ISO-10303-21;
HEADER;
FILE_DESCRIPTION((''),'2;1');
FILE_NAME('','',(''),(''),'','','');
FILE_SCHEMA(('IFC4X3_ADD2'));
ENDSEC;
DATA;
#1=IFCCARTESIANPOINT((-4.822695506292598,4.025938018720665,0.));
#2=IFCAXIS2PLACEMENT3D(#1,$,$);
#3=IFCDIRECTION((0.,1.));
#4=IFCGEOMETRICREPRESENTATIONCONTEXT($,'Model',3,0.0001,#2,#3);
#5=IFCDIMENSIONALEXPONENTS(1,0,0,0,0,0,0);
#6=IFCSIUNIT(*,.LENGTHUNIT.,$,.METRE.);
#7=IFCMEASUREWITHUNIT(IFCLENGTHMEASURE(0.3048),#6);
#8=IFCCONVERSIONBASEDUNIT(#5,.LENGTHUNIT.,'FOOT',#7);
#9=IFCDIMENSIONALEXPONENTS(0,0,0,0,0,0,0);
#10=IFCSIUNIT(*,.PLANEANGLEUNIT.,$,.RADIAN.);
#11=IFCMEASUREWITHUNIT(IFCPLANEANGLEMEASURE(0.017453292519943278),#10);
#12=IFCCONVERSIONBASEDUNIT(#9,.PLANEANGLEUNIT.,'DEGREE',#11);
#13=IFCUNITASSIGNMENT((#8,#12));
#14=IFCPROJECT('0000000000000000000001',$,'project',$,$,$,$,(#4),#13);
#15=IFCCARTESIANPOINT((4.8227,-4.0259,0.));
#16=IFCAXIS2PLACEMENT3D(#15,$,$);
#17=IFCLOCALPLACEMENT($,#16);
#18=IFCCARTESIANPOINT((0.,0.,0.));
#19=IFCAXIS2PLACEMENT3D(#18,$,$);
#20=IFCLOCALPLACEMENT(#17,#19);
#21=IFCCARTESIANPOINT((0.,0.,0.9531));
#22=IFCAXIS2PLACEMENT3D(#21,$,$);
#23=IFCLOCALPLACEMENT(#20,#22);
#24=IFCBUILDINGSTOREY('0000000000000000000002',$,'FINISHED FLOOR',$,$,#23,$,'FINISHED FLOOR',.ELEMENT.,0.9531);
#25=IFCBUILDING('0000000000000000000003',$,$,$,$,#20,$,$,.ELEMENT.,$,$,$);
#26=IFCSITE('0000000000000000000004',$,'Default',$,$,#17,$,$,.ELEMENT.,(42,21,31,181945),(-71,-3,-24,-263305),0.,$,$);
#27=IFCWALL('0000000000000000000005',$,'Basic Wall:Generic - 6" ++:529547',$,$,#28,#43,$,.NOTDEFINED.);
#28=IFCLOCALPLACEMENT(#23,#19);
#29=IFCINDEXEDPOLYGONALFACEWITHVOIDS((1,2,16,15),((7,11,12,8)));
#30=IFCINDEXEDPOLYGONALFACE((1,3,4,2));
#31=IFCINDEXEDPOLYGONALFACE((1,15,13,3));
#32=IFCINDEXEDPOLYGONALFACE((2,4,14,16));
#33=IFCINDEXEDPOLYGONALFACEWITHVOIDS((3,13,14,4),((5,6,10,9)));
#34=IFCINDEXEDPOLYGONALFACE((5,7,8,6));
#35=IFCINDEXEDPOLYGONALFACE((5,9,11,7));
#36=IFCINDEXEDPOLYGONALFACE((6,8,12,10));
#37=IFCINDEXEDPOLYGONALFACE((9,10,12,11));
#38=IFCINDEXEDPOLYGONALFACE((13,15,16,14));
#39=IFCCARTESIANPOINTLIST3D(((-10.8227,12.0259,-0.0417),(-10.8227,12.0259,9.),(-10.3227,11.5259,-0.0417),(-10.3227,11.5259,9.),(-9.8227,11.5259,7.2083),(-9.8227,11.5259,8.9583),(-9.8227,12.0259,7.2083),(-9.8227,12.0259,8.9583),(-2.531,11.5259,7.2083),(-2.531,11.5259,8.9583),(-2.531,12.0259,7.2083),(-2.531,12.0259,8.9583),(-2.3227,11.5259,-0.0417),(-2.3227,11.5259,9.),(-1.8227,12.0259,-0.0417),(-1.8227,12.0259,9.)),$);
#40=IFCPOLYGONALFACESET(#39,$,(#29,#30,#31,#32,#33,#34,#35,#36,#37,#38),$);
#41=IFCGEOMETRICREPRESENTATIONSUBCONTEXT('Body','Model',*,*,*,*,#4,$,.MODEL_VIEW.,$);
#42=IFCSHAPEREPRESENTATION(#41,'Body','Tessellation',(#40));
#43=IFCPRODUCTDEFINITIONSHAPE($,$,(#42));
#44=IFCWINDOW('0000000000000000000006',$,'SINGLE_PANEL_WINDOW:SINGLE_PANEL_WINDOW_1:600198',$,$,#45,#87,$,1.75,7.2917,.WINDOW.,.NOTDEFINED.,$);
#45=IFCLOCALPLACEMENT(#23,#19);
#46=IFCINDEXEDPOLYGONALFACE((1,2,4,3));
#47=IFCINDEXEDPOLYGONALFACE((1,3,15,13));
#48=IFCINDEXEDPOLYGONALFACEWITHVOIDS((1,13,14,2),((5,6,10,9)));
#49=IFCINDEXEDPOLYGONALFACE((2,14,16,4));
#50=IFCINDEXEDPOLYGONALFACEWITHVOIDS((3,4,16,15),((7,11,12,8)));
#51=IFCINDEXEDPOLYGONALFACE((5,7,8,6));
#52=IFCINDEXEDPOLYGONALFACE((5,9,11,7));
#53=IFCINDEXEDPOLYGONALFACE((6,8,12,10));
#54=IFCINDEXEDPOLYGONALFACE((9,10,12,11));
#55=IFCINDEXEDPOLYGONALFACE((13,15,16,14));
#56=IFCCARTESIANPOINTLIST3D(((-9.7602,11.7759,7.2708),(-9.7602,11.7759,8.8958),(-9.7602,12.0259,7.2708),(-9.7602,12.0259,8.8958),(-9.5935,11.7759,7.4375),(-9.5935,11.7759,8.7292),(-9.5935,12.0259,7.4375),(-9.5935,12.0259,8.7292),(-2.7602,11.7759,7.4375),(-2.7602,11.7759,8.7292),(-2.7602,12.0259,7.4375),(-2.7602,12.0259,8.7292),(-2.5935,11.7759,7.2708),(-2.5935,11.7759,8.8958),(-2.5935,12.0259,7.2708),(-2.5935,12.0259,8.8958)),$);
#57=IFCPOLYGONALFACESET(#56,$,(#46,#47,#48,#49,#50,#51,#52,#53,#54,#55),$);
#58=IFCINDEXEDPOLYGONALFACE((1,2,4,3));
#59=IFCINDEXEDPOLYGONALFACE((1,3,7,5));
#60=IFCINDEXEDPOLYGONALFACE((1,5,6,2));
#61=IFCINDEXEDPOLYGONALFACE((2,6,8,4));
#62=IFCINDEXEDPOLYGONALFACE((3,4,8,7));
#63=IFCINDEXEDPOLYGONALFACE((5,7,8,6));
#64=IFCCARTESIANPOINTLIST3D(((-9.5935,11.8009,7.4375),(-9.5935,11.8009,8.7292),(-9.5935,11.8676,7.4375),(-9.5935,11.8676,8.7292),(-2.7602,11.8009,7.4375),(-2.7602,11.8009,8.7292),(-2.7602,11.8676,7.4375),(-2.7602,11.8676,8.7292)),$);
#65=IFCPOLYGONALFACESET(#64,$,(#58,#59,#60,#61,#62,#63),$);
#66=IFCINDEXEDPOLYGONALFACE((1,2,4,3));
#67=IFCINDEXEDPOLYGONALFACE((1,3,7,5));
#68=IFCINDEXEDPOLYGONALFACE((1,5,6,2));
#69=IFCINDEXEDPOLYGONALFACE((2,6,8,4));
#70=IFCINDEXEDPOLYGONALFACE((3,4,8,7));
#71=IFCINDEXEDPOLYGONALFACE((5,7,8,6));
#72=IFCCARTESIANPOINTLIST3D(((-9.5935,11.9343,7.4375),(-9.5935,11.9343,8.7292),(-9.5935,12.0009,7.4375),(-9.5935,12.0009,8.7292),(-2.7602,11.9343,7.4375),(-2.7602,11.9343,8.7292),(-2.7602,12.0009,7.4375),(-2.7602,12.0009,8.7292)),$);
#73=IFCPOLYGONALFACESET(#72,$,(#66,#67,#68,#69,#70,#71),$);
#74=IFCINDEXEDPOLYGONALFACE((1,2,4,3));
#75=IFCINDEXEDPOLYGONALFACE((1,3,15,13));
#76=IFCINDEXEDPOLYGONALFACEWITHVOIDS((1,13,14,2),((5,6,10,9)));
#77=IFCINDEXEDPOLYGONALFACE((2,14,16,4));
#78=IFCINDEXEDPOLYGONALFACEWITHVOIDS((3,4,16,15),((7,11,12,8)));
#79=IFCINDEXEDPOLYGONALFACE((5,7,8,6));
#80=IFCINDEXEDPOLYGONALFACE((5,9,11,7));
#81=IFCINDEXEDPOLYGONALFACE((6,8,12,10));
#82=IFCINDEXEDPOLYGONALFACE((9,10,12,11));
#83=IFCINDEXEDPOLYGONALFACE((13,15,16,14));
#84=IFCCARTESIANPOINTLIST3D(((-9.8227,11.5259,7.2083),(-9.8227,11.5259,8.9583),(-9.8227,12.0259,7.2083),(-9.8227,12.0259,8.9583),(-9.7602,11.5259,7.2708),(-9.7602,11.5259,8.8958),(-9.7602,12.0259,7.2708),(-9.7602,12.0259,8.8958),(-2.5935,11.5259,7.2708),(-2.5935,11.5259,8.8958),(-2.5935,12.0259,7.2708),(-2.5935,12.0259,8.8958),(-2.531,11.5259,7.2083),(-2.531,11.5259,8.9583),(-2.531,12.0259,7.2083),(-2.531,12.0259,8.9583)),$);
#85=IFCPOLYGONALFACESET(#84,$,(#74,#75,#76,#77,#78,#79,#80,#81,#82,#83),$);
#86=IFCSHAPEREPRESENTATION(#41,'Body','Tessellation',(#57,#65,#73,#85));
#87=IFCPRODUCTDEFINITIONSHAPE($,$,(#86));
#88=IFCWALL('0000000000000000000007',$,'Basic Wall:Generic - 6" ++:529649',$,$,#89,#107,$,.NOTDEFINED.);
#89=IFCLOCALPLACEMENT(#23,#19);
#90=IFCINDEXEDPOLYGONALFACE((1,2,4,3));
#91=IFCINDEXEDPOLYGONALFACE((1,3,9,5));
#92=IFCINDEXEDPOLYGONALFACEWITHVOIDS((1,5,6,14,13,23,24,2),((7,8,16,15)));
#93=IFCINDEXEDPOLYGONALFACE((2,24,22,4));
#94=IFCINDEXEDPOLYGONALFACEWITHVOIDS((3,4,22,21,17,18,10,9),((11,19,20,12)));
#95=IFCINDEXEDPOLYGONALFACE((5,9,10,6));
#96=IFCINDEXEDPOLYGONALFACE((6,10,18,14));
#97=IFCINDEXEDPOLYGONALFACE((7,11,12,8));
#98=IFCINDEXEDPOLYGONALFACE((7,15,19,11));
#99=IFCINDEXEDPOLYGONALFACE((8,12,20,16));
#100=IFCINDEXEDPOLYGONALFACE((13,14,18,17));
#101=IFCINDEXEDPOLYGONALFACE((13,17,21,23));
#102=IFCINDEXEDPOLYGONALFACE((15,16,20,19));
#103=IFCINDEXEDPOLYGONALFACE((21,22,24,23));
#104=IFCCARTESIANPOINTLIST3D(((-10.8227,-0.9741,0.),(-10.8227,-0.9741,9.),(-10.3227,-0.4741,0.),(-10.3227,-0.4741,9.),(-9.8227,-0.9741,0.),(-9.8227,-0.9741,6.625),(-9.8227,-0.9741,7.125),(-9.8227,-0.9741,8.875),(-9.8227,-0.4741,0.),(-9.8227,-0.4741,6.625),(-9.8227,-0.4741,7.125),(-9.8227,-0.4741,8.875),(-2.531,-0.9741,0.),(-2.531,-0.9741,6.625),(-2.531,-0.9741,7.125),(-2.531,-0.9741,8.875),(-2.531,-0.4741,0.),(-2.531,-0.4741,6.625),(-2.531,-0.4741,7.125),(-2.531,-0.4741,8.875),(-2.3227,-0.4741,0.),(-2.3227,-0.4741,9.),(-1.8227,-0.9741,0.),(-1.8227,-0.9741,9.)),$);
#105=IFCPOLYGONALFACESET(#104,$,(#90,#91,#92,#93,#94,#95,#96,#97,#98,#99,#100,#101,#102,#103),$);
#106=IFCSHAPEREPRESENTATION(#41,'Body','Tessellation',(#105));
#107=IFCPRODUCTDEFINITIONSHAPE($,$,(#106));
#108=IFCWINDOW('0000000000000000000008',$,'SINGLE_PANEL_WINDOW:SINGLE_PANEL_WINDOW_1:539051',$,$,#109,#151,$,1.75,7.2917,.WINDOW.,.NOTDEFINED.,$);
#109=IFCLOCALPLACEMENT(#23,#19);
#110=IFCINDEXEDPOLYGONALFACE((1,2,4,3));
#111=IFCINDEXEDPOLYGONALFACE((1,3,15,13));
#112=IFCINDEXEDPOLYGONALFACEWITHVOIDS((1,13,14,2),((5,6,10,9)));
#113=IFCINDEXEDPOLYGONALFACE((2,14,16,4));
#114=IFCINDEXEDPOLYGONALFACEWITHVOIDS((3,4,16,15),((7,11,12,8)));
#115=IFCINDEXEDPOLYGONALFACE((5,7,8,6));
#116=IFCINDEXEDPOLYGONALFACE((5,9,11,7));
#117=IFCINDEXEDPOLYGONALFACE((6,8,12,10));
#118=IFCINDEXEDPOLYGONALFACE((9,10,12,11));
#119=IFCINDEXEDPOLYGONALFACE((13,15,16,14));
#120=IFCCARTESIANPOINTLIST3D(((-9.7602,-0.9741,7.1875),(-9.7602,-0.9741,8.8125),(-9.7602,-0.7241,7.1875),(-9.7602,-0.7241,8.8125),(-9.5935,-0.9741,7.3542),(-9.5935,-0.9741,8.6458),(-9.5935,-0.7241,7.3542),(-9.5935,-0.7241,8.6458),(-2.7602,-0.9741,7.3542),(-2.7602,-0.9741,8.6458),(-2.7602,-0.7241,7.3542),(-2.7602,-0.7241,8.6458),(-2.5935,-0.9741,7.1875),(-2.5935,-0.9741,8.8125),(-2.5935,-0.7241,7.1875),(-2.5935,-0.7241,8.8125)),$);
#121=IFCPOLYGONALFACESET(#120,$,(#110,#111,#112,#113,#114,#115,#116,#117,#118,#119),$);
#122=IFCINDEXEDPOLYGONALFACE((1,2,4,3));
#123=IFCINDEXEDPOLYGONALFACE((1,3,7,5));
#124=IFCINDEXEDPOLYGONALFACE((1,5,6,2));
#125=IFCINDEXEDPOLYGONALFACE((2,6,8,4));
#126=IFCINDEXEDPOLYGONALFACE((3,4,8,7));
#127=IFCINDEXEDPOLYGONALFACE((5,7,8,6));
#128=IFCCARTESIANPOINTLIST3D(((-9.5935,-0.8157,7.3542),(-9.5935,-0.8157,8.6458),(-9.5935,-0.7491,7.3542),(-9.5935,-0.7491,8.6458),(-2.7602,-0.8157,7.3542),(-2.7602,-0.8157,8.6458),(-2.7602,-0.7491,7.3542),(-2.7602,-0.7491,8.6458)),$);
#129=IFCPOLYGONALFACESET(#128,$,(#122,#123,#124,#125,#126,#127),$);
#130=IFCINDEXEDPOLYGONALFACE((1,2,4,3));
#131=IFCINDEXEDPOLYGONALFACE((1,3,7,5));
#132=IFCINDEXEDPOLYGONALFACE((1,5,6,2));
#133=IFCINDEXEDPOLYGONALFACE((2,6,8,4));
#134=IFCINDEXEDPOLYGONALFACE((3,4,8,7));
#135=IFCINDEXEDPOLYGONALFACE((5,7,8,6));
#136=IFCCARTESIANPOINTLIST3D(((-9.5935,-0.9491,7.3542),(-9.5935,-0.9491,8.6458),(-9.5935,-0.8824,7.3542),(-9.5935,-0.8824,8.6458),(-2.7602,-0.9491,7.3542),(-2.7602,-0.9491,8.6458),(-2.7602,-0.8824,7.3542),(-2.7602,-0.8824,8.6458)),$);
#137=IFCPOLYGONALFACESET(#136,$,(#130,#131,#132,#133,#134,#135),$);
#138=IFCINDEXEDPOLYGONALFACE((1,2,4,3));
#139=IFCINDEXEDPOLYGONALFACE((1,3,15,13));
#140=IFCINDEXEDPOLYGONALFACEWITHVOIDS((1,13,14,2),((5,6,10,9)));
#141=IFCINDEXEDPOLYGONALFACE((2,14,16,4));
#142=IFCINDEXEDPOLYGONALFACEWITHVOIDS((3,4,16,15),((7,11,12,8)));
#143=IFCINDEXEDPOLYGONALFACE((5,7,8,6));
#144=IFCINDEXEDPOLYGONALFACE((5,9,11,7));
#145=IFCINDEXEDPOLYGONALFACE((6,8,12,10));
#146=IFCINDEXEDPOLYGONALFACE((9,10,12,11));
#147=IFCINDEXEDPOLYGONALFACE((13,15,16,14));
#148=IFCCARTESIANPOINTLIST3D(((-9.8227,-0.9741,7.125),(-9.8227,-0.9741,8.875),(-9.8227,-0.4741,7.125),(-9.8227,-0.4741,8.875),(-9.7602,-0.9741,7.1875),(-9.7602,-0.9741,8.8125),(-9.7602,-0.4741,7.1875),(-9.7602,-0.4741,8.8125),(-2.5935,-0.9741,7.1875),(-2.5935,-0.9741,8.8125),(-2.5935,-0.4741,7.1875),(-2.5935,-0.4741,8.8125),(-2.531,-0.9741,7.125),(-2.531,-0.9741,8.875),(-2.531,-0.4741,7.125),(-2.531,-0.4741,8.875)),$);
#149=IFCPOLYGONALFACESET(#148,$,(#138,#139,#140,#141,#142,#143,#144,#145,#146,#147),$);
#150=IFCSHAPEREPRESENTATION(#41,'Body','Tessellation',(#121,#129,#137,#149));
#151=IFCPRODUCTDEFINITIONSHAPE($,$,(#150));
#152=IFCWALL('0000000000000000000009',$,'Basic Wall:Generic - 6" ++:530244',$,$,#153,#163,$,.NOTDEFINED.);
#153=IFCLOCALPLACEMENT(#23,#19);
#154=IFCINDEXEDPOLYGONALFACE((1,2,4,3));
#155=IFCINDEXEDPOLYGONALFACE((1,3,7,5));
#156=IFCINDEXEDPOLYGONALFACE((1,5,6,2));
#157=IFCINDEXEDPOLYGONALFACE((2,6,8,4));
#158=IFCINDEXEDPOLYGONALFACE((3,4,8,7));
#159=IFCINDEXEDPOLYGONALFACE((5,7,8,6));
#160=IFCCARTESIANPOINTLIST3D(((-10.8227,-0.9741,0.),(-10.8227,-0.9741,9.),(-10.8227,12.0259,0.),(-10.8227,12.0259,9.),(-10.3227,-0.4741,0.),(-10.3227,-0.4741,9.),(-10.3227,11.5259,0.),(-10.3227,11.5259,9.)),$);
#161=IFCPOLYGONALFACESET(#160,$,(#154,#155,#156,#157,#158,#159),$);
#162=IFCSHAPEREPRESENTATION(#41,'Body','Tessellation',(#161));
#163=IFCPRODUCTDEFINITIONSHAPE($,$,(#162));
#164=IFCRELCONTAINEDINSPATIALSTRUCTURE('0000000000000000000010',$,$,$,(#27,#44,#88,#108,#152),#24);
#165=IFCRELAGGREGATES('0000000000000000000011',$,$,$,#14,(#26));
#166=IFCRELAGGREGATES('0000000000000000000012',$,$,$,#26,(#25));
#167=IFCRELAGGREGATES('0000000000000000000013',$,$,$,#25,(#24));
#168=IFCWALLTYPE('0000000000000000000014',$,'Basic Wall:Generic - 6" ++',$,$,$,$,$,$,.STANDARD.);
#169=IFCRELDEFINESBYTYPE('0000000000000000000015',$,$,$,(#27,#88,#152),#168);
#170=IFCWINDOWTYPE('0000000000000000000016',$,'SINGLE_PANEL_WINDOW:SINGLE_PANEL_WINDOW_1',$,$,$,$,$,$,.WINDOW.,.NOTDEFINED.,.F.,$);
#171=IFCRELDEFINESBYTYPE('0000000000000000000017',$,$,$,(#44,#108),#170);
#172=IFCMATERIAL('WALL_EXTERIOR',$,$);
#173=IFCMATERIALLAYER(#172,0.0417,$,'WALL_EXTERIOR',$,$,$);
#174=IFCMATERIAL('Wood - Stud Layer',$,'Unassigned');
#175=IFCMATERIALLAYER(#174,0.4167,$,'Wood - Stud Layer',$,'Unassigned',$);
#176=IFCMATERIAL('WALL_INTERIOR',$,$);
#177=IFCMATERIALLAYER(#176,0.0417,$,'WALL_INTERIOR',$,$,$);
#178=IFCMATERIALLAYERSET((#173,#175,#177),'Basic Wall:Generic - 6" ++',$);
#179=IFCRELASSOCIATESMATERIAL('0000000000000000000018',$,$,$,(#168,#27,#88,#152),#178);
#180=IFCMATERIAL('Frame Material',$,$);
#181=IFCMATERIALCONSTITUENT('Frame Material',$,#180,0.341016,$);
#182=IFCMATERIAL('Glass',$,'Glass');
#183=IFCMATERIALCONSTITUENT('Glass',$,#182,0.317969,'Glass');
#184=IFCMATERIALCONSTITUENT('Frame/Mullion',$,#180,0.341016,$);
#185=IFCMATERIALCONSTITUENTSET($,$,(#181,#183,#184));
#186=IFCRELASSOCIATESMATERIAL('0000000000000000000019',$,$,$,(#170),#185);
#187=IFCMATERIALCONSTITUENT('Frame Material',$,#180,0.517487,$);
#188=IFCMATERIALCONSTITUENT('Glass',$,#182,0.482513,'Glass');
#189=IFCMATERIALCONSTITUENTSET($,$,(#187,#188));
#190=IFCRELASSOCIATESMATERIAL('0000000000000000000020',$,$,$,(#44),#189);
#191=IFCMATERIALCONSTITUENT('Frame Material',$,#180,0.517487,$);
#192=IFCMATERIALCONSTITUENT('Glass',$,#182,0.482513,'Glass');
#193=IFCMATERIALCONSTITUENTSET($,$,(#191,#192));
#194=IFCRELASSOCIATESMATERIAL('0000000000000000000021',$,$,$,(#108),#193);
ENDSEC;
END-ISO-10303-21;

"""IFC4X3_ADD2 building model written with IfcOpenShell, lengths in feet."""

from ifc_helpers import new_model, entity, si_unit, converted_unit, direction, frame, frame_2d, origin, origin_2d_with_axis, place, context, subcontext, project, spatial, polyline, rectangle, outline, extrude, source, transform, mapped, material, layer, layer_set, constituent, constituent_set, type_object, type_shapes, element, fill, save


model = new_model("IFC4X3_ADD2")

# Units and contexts
model_context = context("Model", 3, precision=0.0001, world=frame((-4.822695506292598, 4.025938018720665, 0.0)), true_north=direction((0.0, 1.0)))
body_context = subcontext(model_context, "Body", "Model", "MODEL_VIEW")
ifc_project = project(units=[converted_unit("LENGTHUNIT", "FOOT", entity("IfcLengthMeasure", 0.3048), si_unit("LENGTHUNIT", "METRE"), dimensions=[1, 0, 0, 0, 0, 0, 0]), converted_unit("PLANEANGLEUNIT", "DEGREE", entity("IfcPlaneAngleMeasure", 0.017453292519943278), si_unit("PLANEANGLEUNIT", "RADIAN"), dimensions=[0, 0, 0, 0, 0, 0, 0])], contexts=[model_context])

# Site, building, storey
site_placement = place(None, frame((4.8227, -4.0259, 0.0)))
site = spatial("IfcSite", under=ifc_project, at=site_placement, Name="Default", CompositionType="ELEMENT", RefLatitude=(42, 21, 31, 181945), RefLongitude=(-71, -3, -24, -263305), RefElevation=0.0)
building_placement = place(site_placement, origin())
building = spatial("IfcBuilding", under=site, at=building_placement, CompositionType="ELEMENT")
storey_placement = place(building_placement, frame((0.0, 0.0, 0.9531)))
storey = spatial("IfcBuildingStorey", under=building, at=storey_placement, Name="FINISHED FLOOR", LongName="FINISHED FLOOR", CompositionType="ELEMENT", Elevation=0.9531)

# Wall, opening, window
ifc_material_1 = material(Name="WALL_EXTERIOR")
ifc_layer_1 = layer(ifc_material_1, 0.0417, Name="WALL_EXTERIOR")
ifc_material_2 = material(Name="Wood - Stud Layer", Category="Unassigned")
ifc_layer_2 = layer(ifc_material_2, 0.4167, Name="Wood - Stud Layer", Category="Unassigned")
ifc_material_3 = material(Name="WALL_INTERIOR")
ifc_layer_3 = layer(ifc_material_3, 0.0417, Name="WALL_INTERIOR")
ifc_layer_set_1 = layer_set([ifc_layer_1, ifc_layer_2, ifc_layer_3], Name="Basic Wall:Generic - 6\" ++")
wall_type_1 = type_object("IfcWallType", Name="Basic Wall:Generic - 6\" ++", PredefinedType="STANDARD", material=ifc_layer_set_1)
wall_1_placement = place(storey_placement, frame((-10.8227, 11.7759, -0.0417)))
wall_1 = element("IfcWall", 1, at=wall_1_placement, inside=storey, type_object=wall_type_1, material=ifc_layer_set_1, Name="Basic Wall:Generic - 6\" ++:529547", PredefinedType="NOTDEFINED", context=body_context, shape_type="SweptSolid", body=[
    extrude(outline(polyline([(8.5, -0.25), (9.0, 0.25), (0.0, 0.25), (0.5, -0.25), (8.5, -0.25)])), origin(), (0.0, 0.0, 1.0), 9.0417),
])
opening_1_placement = place(wall_1_placement, frame((1.0, -0.25, 7.25)))
opening_1 = element("IfcOpeningElement", 2, at=opening_1_placement, cuts=wall_1, PredefinedType="OPENING", context=body_context, shape_type="SweptSolid", body=[
    extrude(rectangle(XDim=1.75, YDim=7.2917, at=frame_2d((0.875, 3.6458), x_axis=(-1.0, 0.0))), frame((0.0, 0.0, 0.0), z_axis=(0.0, 1.0, 0.0), x_axis=(0.0, 0.0, 1.0)), (0.0, 0.0, 1.0), 0.5),
])
ifc_material_4 = material(Name="Frame Material")
ifc_constituent_1 = constituent(ifc_material_4, Name="Frame Material", fraction=0.517487)
ifc_material_5 = material(Name="Glass", Category="Glass")
ifc_constituent_2 = constituent(ifc_material_5, Name="Glass", Category="Glass", fraction=0.482513)
ifc_constituent_set_1 = constituent_set(constituents=[ifc_constituent_1, ifc_constituent_2])
ifc_constituent_3 = constituent(ifc_material_4, Name="Frame Material", fraction=0.341016)
ifc_constituent_4 = constituent(ifc_material_5, Name="Glass", Category="Glass", fraction=0.317969)
ifc_constituent_5 = constituent(ifc_material_4, Name="Frame/Mullion", fraction=0.341016)
ifc_constituent_set_2 = constituent_set(constituents=[ifc_constituent_3, ifc_constituent_4, ifc_constituent_5])
window_type_1 = type_object("IfcWindowType", Name="SINGLE_PANEL_WINDOW:SINGLE_PANEL_WINDOW_1", ParameterTakesPrecedence=False, PartitioningType="NOTDEFINED", PredefinedType="WINDOW", material=ifc_constituent_set_2)
shared_shape_1 = source(origin(), body_context, "Body", "SweptSolid", [
    extrude(outline(polyline([(-3.5833, -0.8125), (3.5833, -0.8125), (3.5833, 0.8125), (-3.5833, 0.8125), (-3.5833, -0.8125)]), holes=[polyline([(3.4167, 0.6458), (3.4167, -0.6458), (-3.4167, -0.6458), (-3.4167, 0.6458), (3.4167, 0.6458)])]), frame((3.6458, 0.5, 0.875), z_axis=(0.0, -1.0, 0.0), x_axis=(-1.0, 0.0, 0.0)), (0.0, 0.0, 1.0), 0.25),
    extrude(rectangle(XDim=6.8333, YDim=0.0667, at=frame_2d((0.0, 0.0), x_axis=(1.0, 0.0))), frame((3.6458, 0.3083, 0.2292), z_axis=(0.0, 0.0, 1.0), x_axis=(-1.0, 0.0, 0.0)), (0.0, 0.0, 1.0), 1.2917),
    extrude(rectangle(XDim=6.8333, YDim=0.0667, at=origin_2d_with_axis()), frame((3.6458, 0.4417, 0.2292), z_axis=(0.0, 0.0, 1.0), x_axis=(-1.0, 0.0, 0.0)), (0.0, 0.0, 1.0), 1.2917),
    extrude(outline(polyline([(-0.875, -3.6458), (0.875, -3.6458), (0.875, 3.6458), (-0.875, 3.6458), (-0.875, -3.6458)]), holes=[polyline([(-0.8125, -3.5833), (-0.8125, 3.5833), (0.8125, 3.5833), (0.8125, -3.5833), (-0.8125, -3.5833)])]), frame((3.6458, 0.5, 0.875), z_axis=(0.0, -1.0, 0.0), x_axis=(0.0, 0.0, -1.0)), (0.0, 0.0, 1.0), 0.5),
])
type_shapes(window_type_1, [shared_shape_1])
window_1_placement = place(opening_1_placement, origin())
window_1 = element("IfcWindow", 3, at=window_1_placement, inside=storey, type_object=window_type_1, material=ifc_constituent_set_1, Name="SINGLE_PANEL_WINDOW:SINGLE_PANEL_WINDOW_1:600198", OverallHeight=1.75, OverallWidth=7.2917, PartitioningType="NOTDEFINED", PredefinedType="WINDOW", context=body_context, shape_type="MappedRepresentation", body=[
    mapped(shared_shape_1, transform((0.0, 0.0, 0.0), scale=1.0)),
])
fill(opening_1, window_1)

# Wall, openings, window
wall_2_placement = place(storey_placement, frame((-1.8227, -0.7241, 0.0), z_axis=(0.0, 0.0, 1.0), x_axis=(-1.0, 0.0, 0.0)))
wall_2 = element("IfcWall", 4, at=wall_2_placement, inside=storey, type_object=wall_type_1, material=ifc_layer_set_1, Name="Basic Wall:Generic - 6\" ++:529649", PredefinedType="NOTDEFINED", context=body_context, shape_type="SweptSolid", body=[
    extrude(outline(polyline([(0.5, -0.25), (8.5, -0.25), (9.0, 0.25), (0.0, 0.25), (0.5, -0.25)])), origin(), (0.0, 0.0, 1.0), 9.0),
])
opening_2_placement = place(wall_2_placement, frame((-1.8227, -0.7241, 0.0), z_axis=(0.0, 0.0, 1.0), x_axis=(-1.0, 0.0, 0.0)))
element("IfcOpeningElement", 5, at=opening_2_placement, cuts=wall_2, PredefinedType="OPENING", context=body_context, shape_type="SweptSolid", body=[
    extrude(rectangle(XDim=6.625, YDim=7.2917, at=origin_2d_with_axis()), frame((-6.1769, -0.4741, 3.3125), z_axis=(0.0, -1.0, 0.0), x_axis=(0.0, 0.0, -1.0)), (0.0, 0.0, 1.0), 0.5),
])
opening_3_placement = place(wall_2_placement, frame((0.7083, -0.25, 7.125)))
opening_3 = element("IfcOpeningElement", 6, at=opening_3_placement, cuts=wall_2, PredefinedType="OPENING", context=body_context, shape_type="SweptSolid", body=[
    extrude(rectangle(XDim=1.75, YDim=7.2917, at=frame_2d((0.875, 3.6458), x_axis=(-1.0, 0.0))), frame((0.0, 0.0, 0.0), z_axis=(0.0, 1.0, 0.0), x_axis=(0.0, 0.0, 1.0)), (0.0, 0.0, 1.0), 0.5),
])
ifc_constituent_6 = constituent(ifc_material_4, Name="Frame Material", fraction=0.517487)
ifc_constituent_7 = constituent(ifc_material_5, Name="Glass", Category="Glass", fraction=0.482513)
ifc_constituent_set_3 = constituent_set(constituents=[ifc_constituent_6, ifc_constituent_7])
window_2_placement = place(opening_3_placement, origin())
window_2 = element("IfcWindow", 7, at=window_2_placement, inside=storey, type_object=window_type_1, material=ifc_constituent_set_3, Name="SINGLE_PANEL_WINDOW:SINGLE_PANEL_WINDOW_1:539051", OverallHeight=1.75, OverallWidth=7.2917, PartitioningType="NOTDEFINED", PredefinedType="WINDOW", context=body_context, shape_type="MappedRepresentation", body=[
    mapped(shared_shape_1, transform((0.0, 0.0, 0.0), scale=1.0)),
])
fill(opening_3, window_2)

# Wall
wall_3_placement = place(storey_placement, frame((-10.5727, -0.9741, 0.0), z_axis=(0.0, 0.0, 1.0), x_axis=(0.0, 1.0, 0.0)))
element("IfcWall", 8, at=wall_3_placement, inside=storey, type_object=wall_type_1, material=ifc_layer_set_1, Name="Basic Wall:Generic - 6\" ++:530244", PredefinedType="NOTDEFINED", context=body_context, shape_type="SweptSolid", body=[
    extrude(outline(polyline([(12.5, -0.25), (13.0, 0.25), (0.0, 0.25), (0.5, -0.25), (12.5, -0.25)])), origin(), (0.0, 0.0, 1.0), 9.0),
])

save(model, "model.ifc")
